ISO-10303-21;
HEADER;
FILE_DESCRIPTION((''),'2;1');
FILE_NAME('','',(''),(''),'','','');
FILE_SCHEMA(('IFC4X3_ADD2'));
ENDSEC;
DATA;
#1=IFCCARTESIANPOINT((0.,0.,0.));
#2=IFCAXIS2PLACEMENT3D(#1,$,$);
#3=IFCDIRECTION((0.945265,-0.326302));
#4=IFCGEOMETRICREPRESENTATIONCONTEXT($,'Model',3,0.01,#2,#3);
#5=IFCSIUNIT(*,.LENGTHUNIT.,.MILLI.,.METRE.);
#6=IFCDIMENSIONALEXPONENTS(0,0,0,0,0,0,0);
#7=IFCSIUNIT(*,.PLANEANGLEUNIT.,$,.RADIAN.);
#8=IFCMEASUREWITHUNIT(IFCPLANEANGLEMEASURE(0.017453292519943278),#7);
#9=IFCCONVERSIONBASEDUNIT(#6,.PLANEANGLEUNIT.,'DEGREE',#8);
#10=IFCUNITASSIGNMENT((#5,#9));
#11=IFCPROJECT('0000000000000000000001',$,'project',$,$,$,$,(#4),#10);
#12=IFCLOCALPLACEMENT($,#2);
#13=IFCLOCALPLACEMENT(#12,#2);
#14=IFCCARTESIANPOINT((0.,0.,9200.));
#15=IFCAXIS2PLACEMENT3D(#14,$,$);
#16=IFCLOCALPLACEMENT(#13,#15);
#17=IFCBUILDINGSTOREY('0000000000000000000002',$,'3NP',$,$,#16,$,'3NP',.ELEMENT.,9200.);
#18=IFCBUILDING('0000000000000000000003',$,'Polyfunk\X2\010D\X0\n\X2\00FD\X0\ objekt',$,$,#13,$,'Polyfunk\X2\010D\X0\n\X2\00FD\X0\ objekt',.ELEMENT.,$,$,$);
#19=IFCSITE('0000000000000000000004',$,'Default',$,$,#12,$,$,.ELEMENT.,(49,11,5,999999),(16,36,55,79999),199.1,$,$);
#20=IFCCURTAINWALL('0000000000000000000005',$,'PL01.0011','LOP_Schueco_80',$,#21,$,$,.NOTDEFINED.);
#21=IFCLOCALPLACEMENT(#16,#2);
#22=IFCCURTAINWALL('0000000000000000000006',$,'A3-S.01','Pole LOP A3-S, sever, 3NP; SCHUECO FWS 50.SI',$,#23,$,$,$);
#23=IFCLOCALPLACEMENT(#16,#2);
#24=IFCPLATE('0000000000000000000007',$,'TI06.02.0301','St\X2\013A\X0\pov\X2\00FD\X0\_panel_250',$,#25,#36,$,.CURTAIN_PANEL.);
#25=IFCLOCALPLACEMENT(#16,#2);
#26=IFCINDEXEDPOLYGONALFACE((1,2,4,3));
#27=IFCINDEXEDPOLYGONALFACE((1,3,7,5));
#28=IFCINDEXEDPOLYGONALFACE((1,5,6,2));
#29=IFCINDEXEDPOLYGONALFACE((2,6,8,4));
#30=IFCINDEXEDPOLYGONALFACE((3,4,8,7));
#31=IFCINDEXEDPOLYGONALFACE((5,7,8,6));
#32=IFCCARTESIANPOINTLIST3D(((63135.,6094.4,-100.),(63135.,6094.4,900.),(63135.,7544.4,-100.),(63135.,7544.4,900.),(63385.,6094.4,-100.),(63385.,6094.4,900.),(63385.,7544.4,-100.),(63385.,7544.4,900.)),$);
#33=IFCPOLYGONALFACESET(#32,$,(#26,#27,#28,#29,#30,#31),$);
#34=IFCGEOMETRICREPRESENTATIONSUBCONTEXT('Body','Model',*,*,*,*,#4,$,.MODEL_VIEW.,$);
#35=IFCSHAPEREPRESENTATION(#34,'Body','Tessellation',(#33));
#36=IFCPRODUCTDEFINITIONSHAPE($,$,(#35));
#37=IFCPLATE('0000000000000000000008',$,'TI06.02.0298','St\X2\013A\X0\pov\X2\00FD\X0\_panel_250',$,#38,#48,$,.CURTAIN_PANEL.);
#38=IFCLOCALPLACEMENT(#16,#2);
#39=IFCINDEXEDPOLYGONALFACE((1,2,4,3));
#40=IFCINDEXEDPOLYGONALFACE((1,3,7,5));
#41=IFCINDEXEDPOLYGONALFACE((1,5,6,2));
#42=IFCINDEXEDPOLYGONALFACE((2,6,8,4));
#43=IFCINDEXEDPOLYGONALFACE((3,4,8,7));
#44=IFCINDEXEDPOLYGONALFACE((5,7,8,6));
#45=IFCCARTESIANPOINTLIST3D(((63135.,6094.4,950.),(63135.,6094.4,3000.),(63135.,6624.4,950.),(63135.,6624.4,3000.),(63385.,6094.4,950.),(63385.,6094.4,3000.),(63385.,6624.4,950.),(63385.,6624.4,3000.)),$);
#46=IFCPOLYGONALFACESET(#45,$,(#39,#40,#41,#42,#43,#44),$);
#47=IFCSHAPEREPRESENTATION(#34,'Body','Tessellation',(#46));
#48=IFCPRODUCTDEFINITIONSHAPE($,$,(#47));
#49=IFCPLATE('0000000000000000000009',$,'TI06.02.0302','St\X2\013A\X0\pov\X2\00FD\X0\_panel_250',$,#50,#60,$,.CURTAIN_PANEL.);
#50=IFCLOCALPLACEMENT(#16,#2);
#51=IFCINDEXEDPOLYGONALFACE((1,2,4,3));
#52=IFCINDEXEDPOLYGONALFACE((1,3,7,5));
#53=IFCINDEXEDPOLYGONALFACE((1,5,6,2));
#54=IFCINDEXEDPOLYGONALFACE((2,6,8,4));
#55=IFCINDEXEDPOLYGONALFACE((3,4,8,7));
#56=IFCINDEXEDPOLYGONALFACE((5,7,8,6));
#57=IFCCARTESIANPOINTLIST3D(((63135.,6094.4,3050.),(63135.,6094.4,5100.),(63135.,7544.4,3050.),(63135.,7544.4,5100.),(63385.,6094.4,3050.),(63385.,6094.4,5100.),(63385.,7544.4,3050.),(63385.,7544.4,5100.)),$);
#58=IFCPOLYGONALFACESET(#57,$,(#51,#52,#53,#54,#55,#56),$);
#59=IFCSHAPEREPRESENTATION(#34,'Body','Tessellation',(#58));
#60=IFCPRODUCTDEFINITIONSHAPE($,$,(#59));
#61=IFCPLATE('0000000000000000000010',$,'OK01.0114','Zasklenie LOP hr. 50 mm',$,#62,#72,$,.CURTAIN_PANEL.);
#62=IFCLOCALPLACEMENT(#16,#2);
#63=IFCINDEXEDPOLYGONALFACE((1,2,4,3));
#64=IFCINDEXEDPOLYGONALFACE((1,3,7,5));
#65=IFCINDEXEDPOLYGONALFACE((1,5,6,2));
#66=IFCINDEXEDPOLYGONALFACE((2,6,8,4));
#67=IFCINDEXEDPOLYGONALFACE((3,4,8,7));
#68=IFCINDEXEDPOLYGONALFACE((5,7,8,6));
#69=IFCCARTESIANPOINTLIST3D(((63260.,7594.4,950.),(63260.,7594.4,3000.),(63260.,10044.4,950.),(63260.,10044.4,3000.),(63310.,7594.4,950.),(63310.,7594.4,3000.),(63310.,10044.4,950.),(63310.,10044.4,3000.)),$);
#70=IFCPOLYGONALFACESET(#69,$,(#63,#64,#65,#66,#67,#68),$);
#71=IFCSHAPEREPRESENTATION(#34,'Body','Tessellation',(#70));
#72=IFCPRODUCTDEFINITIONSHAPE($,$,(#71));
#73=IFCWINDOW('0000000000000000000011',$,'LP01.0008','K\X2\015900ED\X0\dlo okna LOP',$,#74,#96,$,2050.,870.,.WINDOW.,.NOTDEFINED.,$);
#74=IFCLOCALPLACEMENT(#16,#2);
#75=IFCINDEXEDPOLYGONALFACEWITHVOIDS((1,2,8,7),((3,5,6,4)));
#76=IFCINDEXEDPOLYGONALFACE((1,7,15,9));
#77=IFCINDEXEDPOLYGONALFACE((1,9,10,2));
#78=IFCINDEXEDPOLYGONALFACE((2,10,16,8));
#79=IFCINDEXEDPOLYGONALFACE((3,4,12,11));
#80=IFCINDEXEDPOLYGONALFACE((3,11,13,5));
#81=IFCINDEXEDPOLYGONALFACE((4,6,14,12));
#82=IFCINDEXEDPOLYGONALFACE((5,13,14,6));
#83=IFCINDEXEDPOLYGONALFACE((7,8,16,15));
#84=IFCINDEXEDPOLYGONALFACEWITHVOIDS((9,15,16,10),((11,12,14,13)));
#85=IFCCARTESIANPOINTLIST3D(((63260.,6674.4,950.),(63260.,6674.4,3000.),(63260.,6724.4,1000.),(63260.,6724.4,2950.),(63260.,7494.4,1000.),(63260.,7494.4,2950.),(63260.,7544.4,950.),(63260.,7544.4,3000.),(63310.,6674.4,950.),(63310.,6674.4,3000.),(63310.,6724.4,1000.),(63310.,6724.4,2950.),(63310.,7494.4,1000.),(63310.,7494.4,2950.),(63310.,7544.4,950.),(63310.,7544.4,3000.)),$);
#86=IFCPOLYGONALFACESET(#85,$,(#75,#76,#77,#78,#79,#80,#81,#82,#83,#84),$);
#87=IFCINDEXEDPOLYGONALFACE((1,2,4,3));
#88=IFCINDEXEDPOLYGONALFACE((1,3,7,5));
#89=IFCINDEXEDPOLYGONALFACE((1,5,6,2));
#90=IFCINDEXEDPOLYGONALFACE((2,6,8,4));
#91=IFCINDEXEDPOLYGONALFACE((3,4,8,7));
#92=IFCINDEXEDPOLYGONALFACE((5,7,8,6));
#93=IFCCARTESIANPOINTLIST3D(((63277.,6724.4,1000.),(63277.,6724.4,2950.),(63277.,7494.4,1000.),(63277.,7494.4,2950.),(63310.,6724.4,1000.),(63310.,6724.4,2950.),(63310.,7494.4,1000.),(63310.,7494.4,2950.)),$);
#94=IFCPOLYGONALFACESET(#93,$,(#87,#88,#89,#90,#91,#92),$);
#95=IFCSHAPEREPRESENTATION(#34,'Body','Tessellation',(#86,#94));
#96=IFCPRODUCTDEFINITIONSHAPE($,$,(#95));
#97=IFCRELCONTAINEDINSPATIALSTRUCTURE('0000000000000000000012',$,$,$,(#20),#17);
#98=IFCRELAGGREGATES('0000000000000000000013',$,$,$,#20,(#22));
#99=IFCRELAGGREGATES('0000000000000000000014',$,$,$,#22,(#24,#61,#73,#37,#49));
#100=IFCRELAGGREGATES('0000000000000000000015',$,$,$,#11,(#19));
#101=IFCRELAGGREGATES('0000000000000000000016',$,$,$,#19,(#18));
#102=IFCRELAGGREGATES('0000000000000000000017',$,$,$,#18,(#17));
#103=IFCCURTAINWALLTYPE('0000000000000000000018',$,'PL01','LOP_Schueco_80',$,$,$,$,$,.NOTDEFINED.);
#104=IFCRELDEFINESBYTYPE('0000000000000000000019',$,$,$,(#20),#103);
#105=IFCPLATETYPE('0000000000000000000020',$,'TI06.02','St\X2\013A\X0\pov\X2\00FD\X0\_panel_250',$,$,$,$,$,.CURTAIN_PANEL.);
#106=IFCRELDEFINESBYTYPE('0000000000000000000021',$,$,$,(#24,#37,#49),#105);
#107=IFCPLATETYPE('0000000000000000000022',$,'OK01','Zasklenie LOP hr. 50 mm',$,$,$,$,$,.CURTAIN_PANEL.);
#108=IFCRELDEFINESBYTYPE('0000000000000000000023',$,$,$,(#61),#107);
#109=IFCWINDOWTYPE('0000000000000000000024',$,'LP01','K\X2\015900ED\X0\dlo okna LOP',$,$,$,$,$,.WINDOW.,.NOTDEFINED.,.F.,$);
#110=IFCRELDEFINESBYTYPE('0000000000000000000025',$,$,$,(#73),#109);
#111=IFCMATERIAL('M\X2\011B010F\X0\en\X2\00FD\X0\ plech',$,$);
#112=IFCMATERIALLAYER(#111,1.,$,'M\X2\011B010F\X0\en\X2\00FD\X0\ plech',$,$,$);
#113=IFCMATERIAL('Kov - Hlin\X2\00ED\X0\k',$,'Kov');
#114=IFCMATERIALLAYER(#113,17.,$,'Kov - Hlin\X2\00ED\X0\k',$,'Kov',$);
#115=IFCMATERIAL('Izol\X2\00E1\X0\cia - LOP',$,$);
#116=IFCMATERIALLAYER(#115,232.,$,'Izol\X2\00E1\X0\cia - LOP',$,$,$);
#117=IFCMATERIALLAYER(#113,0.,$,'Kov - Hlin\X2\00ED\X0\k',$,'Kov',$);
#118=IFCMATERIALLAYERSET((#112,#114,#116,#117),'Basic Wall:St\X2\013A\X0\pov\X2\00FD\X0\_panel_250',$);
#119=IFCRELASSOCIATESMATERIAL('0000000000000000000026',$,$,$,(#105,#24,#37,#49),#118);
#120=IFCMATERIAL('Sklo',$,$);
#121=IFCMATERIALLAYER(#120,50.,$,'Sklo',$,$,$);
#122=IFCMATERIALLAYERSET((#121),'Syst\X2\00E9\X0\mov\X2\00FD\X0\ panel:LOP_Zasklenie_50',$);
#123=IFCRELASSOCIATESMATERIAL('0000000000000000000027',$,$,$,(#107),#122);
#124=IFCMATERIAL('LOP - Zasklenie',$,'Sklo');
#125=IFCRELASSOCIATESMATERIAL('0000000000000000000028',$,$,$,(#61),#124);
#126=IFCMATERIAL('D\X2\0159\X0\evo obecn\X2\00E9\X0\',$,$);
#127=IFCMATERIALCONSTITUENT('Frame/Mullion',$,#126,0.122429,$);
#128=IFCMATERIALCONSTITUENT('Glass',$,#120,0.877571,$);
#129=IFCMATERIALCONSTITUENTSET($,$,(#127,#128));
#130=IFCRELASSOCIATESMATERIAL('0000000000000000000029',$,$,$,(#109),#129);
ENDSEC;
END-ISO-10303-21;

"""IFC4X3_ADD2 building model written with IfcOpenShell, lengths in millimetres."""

from ifc_helpers import new_model, entity, si_unit, converted_unit, direction, frame, frame_2d, origin, origin_2d_with_axis, place, context, subcontext, project, spatial, polyline, rectangle, outline, extrude, source, transform, mapped, material, layer, layer_set, layer_usage, constituent, constituent_set, type_object, type_shapes, element, aggregate, save


model = new_model("IFC4X3_ADD2")

# Units and contexts
model_context = context("Model", 3, precision=0.01, world=origin(), true_north=direction((0.945265, -0.326302)))
body_context = subcontext(model_context, "Body", "Model", "MODEL_VIEW")
ifc_project = project(units=[si_unit("LENGTHUNIT", "METRE", prefix="MILLI"), converted_unit("PLANEANGLEUNIT", "DEGREE", entity("IfcPlaneAngleMeasure", 0.017453292519943278), si_unit("PLANEANGLEUNIT", "RADIAN"), dimensions=[0, 0, 0, 0, 0, 0, 0])], contexts=[model_context])

# Site, building, storey
site_placement = place(None, origin())
site = spatial("IfcSite", under=ifc_project, at=site_placement, Name="Default", CompositionType="ELEMENT", RefLatitude=(49, 11, 5, 999999), RefLongitude=(16, 36, 55, 79999), RefElevation=199.1)
building_placement = place(site_placement, origin())
building = spatial("IfcBuilding", under=site, at=building_placement, Name="Polyfunkčný objekt", LongName="Polyfunkčný objekt", CompositionType="ELEMENT")
storey_placement = place(building_placement, frame((0.0, 0.0, 9200.0)))
storey = spatial("IfcBuildingStorey", under=building, at=storey_placement, Name="3NP", LongName="3NP", CompositionType="ELEMENT", Elevation=9200.0)

# Curtain walls, plates, window
curtain_wall_type = type_object("IfcCurtainWallType", Name="PL01", Description="LOP_Schueco_80", PredefinedType="NOTDEFINED")
curtain_wall_1_placement = place(storey_placement, frame((0.0, 0.0, -9200.0)))
curtain_wall_1 = element("IfcCurtainWall", 1, at=curtain_wall_1_placement, inside=storey, type_object=curtain_wall_type, Name="PL01.0011", Description="LOP_Schueco_80", PredefinedType="NOTDEFINED")
curtain_wall_2 = element("IfcCurtainWall", 2, Name="A3-S.01", Description="Pole LOP A3-S, sever, 3NP; SCHUECO FWS 50.SI")
aggregate(curtain_wall_1, [curtain_wall_2])
ifc_material_1 = material(Name="Měďený plech")
ifc_layer_1 = layer(ifc_material_1, 1.0, Name="Měďený plech")
ifc_material_2 = material(Name="Kov - Hliník", Category="Kov")
ifc_layer_2 = layer(ifc_material_2, 17.0, Name="Kov - Hliník", Category="Kov")
ifc_material_3 = material(Name="Izolácia - LOP")
ifc_layer_3 = layer(ifc_material_3, 232.0, Name="Izolácia - LOP")
ifc_layer_4 = layer(ifc_material_2, 0.0, Name="Kov - Hliník", Category="Kov")
ifc_layer_set_1 = layer_set([ifc_layer_1, ifc_layer_2, ifc_layer_3, ifc_layer_4], Name="Basic Wall:Stĺpový_panel_250")
ifc_layer_usage_1 = layer_usage(ifc_layer_set_1, "AXIS2", "NEGATIVE", 125.0)
plate_type_1 = type_object("IfcPlateType", Name="TI06.02", Description="Stĺpový_panel_250", PredefinedType="CURTAIN_PANEL", material=ifc_layer_set_1)
plate_1_placement = place(storey_placement, frame((63260.0, 7544.4, -100.0), z_axis=(0.0, 0.0, 1.0), x_axis=(0.0, -1.0, 0.0)))
plate_1 = element("IfcPlate", 3, at=plate_1_placement, type_object=plate_type_1, material=ifc_layer_usage_1, Name="TI06.02.0301", Description="Stĺpový_panel_250", PredefinedType="CURTAIN_PANEL", context=body_context, shape_type="SweptSolid", body=[
    extrude(rectangle(XDim=250.0, YDim=1450.0, at=frame_2d((0.0, 0.0), x_axis=(1.0, 0.0))), frame((725.0, 0.0, 0.0), z_axis=(0.0, 0.0, 1.0), x_axis=(0.0, 1.0, 0.0)), (0.0, 0.0, 1.0), 1000.0),
])
ifc_layer_usage_2 = layer_usage(ifc_layer_set_1, "AXIS2", "NEGATIVE", 125.0)
plate_2_placement = place(storey_placement, frame((63260.0, 6624.4, 950.0), z_axis=(0.0, 0.0, 1.0), x_axis=(0.0, -1.0, 0.0)))
plate_2 = element("IfcPlate", 4, at=plate_2_placement, type_object=plate_type_1, material=ifc_layer_usage_2, Name="TI06.02.0298", Description="Stĺpový_panel_250", PredefinedType="CURTAIN_PANEL", context=body_context, shape_type="SweptSolid", body=[
    extrude(rectangle(XDim=250.0, YDim=530.0, at=frame_2d((0.0, 0.0), x_axis=(1.0, 0.0))), frame((265.0, 0.0, 0.0), z_axis=(0.0, 0.0, 1.0), x_axis=(0.0, 1.0, 0.0)), (0.0, 0.0, 1.0), 2050.0),
])
ifc_layer_usage_3 = layer_usage(ifc_layer_set_1, "AXIS2", "NEGATIVE", 125.0)
plate_3_placement = place(storey_placement, frame((63260.0, 7544.4, 3050.0), z_axis=(0.0, 0.0, 1.0), x_axis=(0.0, -1.0, 0.0)))
plate_3 = element("IfcPlate", 5, at=plate_3_placement, type_object=plate_type_1, material=ifc_layer_usage_3, Name="TI06.02.0302", Description="Stĺpový_panel_250", PredefinedType="CURTAIN_PANEL", context=body_context, shape_type="SweptSolid", body=[
    extrude(rectangle(XDim=250.0, YDim=1450.0, at=frame_2d((0.0, 0.0), x_axis=(1.0, 0.0))), frame((725.0, 0.0, 0.0), z_axis=(0.0, 0.0, 1.0), x_axis=(0.0, 1.0, 0.0)), (0.0, 0.0, 1.0), 2050.0),
])
ifc_material_4 = material(Name="LOP - Zasklenie", Category="Sklo")
ifc_material_5 = material(Name="Sklo")
ifc_layer_5 = layer(ifc_material_5, 50.0, Name="Sklo")
ifc_layer_set_2 = layer_set([ifc_layer_5], Name="Systémový panel:LOP_Zasklenie_50")
plate_type_2 = type_object("IfcPlateType", Name="OK01", Description="Zasklenie LOP hr. 50 mm", PredefinedType="CURTAIN_PANEL", material=ifc_layer_set_2)
shared_shape_1 = source(origin(), body_context, "Body", "SweptSolid", [
    extrude(rectangle(XDim=50.0, YDim=2450.0, at=origin_2d_with_axis()), frame((0.0, 25.0, 0.0), z_axis=(0.0, 0.0, 1.0), x_axis=(0.0, 1.0, 0.0)), (0.0, 0.0, 1.0), 2050.0),
])
type_shapes(plate_type_2, [shared_shape_1])
plate_4_placement = place(curtain_wall_1_placement, frame((63260.0, 8819.4, 10150.0), z_axis=(0.0, 0.0, 1.0), x_axis=(0.0, -1.0, 0.0)))
plate_4 = element("IfcPlate", 6, at=plate_4_placement, type_object=plate_type_2, material=ifc_material_4, Name="OK01.0114", Description="Zasklenie LOP hr. 50 mm", PredefinedType="CURTAIN_PANEL", context=body_context, shape_type="MappedRepresentation", body=[
    mapped(shared_shape_1, transform((0.0, 0.0, 0.0), scale=1.0)),
])
ifc_material_6 = material(Name="Dřevo obecné")
ifc_constituent_1 = constituent(ifc_material_6, Name="Frame/Mullion", fraction=0.122429)
ifc_constituent_2 = constituent(ifc_material_5, Name="Glass", fraction=0.877571)
ifc_constituent_set = constituent_set(constituents=[ifc_constituent_1, ifc_constituent_2])
window_type = type_object("IfcWindowType", Name="LP01", Description="Křídlo okna LOP", ParameterTakesPrecedence=False, PartitioningType="NOTDEFINED", PredefinedType="WINDOW", material=ifc_constituent_set)
shared_shape_2 = source(origin(), body_context, "Body", "SweptSolid", [
    extrude(outline(polyline([(-1025.0, -435.0), (1025.0, -435.0), (1025.0, 435.0), (-1025.0, 435.0), (-1025.0, -435.0)]), holes=[polyline([(-975.0, -385.0), (-975.0, 385.0), (975.0, 385.0), (975.0, -385.0), (-975.0, -385.0)])]), frame((0.0, 0.0, 1025.0), z_axis=(0.0, 1.0, 0.0), x_axis=(0.0, 0.0, -1.0)), (0.0, 0.0, 1.0), 50.0),
    extrude(rectangle(XDim=33.0, YDim=770.0, at=origin_2d_with_axis()), frame((0.0, 33.5, 50.0), z_axis=(0.0, 0.0, 1.0), x_axis=(0.0, -1.0, 0.0)), (0.0, 0.0, 1.0), 1950.0),
])
type_shapes(window_type, [shared_shape_2])
window_placement = place(curtain_wall_1_placement, frame((63260.0, 7109.4, 10150.0), z_axis=(0.0, 0.0, 1.0), x_axis=(0.0, -1.0, 0.0)))
window = element("IfcWindow", 7, at=window_placement, type_object=window_type, Name="LP01.0008", Description="Křídlo okna LOP", OverallHeight=2050.0, OverallWidth=870.0, PartitioningType="NOTDEFINED", PredefinedType="WINDOW", context=body_context, shape_type="MappedRepresentation", body=[
    mapped(shared_shape_2, transform((0.0, 0.0, 0.0), scale=1.0)),
])
aggregate(curtain_wall_2, [plate_1, plate_4, window, plate_2, plate_3])

save(model, "model.ifc")
